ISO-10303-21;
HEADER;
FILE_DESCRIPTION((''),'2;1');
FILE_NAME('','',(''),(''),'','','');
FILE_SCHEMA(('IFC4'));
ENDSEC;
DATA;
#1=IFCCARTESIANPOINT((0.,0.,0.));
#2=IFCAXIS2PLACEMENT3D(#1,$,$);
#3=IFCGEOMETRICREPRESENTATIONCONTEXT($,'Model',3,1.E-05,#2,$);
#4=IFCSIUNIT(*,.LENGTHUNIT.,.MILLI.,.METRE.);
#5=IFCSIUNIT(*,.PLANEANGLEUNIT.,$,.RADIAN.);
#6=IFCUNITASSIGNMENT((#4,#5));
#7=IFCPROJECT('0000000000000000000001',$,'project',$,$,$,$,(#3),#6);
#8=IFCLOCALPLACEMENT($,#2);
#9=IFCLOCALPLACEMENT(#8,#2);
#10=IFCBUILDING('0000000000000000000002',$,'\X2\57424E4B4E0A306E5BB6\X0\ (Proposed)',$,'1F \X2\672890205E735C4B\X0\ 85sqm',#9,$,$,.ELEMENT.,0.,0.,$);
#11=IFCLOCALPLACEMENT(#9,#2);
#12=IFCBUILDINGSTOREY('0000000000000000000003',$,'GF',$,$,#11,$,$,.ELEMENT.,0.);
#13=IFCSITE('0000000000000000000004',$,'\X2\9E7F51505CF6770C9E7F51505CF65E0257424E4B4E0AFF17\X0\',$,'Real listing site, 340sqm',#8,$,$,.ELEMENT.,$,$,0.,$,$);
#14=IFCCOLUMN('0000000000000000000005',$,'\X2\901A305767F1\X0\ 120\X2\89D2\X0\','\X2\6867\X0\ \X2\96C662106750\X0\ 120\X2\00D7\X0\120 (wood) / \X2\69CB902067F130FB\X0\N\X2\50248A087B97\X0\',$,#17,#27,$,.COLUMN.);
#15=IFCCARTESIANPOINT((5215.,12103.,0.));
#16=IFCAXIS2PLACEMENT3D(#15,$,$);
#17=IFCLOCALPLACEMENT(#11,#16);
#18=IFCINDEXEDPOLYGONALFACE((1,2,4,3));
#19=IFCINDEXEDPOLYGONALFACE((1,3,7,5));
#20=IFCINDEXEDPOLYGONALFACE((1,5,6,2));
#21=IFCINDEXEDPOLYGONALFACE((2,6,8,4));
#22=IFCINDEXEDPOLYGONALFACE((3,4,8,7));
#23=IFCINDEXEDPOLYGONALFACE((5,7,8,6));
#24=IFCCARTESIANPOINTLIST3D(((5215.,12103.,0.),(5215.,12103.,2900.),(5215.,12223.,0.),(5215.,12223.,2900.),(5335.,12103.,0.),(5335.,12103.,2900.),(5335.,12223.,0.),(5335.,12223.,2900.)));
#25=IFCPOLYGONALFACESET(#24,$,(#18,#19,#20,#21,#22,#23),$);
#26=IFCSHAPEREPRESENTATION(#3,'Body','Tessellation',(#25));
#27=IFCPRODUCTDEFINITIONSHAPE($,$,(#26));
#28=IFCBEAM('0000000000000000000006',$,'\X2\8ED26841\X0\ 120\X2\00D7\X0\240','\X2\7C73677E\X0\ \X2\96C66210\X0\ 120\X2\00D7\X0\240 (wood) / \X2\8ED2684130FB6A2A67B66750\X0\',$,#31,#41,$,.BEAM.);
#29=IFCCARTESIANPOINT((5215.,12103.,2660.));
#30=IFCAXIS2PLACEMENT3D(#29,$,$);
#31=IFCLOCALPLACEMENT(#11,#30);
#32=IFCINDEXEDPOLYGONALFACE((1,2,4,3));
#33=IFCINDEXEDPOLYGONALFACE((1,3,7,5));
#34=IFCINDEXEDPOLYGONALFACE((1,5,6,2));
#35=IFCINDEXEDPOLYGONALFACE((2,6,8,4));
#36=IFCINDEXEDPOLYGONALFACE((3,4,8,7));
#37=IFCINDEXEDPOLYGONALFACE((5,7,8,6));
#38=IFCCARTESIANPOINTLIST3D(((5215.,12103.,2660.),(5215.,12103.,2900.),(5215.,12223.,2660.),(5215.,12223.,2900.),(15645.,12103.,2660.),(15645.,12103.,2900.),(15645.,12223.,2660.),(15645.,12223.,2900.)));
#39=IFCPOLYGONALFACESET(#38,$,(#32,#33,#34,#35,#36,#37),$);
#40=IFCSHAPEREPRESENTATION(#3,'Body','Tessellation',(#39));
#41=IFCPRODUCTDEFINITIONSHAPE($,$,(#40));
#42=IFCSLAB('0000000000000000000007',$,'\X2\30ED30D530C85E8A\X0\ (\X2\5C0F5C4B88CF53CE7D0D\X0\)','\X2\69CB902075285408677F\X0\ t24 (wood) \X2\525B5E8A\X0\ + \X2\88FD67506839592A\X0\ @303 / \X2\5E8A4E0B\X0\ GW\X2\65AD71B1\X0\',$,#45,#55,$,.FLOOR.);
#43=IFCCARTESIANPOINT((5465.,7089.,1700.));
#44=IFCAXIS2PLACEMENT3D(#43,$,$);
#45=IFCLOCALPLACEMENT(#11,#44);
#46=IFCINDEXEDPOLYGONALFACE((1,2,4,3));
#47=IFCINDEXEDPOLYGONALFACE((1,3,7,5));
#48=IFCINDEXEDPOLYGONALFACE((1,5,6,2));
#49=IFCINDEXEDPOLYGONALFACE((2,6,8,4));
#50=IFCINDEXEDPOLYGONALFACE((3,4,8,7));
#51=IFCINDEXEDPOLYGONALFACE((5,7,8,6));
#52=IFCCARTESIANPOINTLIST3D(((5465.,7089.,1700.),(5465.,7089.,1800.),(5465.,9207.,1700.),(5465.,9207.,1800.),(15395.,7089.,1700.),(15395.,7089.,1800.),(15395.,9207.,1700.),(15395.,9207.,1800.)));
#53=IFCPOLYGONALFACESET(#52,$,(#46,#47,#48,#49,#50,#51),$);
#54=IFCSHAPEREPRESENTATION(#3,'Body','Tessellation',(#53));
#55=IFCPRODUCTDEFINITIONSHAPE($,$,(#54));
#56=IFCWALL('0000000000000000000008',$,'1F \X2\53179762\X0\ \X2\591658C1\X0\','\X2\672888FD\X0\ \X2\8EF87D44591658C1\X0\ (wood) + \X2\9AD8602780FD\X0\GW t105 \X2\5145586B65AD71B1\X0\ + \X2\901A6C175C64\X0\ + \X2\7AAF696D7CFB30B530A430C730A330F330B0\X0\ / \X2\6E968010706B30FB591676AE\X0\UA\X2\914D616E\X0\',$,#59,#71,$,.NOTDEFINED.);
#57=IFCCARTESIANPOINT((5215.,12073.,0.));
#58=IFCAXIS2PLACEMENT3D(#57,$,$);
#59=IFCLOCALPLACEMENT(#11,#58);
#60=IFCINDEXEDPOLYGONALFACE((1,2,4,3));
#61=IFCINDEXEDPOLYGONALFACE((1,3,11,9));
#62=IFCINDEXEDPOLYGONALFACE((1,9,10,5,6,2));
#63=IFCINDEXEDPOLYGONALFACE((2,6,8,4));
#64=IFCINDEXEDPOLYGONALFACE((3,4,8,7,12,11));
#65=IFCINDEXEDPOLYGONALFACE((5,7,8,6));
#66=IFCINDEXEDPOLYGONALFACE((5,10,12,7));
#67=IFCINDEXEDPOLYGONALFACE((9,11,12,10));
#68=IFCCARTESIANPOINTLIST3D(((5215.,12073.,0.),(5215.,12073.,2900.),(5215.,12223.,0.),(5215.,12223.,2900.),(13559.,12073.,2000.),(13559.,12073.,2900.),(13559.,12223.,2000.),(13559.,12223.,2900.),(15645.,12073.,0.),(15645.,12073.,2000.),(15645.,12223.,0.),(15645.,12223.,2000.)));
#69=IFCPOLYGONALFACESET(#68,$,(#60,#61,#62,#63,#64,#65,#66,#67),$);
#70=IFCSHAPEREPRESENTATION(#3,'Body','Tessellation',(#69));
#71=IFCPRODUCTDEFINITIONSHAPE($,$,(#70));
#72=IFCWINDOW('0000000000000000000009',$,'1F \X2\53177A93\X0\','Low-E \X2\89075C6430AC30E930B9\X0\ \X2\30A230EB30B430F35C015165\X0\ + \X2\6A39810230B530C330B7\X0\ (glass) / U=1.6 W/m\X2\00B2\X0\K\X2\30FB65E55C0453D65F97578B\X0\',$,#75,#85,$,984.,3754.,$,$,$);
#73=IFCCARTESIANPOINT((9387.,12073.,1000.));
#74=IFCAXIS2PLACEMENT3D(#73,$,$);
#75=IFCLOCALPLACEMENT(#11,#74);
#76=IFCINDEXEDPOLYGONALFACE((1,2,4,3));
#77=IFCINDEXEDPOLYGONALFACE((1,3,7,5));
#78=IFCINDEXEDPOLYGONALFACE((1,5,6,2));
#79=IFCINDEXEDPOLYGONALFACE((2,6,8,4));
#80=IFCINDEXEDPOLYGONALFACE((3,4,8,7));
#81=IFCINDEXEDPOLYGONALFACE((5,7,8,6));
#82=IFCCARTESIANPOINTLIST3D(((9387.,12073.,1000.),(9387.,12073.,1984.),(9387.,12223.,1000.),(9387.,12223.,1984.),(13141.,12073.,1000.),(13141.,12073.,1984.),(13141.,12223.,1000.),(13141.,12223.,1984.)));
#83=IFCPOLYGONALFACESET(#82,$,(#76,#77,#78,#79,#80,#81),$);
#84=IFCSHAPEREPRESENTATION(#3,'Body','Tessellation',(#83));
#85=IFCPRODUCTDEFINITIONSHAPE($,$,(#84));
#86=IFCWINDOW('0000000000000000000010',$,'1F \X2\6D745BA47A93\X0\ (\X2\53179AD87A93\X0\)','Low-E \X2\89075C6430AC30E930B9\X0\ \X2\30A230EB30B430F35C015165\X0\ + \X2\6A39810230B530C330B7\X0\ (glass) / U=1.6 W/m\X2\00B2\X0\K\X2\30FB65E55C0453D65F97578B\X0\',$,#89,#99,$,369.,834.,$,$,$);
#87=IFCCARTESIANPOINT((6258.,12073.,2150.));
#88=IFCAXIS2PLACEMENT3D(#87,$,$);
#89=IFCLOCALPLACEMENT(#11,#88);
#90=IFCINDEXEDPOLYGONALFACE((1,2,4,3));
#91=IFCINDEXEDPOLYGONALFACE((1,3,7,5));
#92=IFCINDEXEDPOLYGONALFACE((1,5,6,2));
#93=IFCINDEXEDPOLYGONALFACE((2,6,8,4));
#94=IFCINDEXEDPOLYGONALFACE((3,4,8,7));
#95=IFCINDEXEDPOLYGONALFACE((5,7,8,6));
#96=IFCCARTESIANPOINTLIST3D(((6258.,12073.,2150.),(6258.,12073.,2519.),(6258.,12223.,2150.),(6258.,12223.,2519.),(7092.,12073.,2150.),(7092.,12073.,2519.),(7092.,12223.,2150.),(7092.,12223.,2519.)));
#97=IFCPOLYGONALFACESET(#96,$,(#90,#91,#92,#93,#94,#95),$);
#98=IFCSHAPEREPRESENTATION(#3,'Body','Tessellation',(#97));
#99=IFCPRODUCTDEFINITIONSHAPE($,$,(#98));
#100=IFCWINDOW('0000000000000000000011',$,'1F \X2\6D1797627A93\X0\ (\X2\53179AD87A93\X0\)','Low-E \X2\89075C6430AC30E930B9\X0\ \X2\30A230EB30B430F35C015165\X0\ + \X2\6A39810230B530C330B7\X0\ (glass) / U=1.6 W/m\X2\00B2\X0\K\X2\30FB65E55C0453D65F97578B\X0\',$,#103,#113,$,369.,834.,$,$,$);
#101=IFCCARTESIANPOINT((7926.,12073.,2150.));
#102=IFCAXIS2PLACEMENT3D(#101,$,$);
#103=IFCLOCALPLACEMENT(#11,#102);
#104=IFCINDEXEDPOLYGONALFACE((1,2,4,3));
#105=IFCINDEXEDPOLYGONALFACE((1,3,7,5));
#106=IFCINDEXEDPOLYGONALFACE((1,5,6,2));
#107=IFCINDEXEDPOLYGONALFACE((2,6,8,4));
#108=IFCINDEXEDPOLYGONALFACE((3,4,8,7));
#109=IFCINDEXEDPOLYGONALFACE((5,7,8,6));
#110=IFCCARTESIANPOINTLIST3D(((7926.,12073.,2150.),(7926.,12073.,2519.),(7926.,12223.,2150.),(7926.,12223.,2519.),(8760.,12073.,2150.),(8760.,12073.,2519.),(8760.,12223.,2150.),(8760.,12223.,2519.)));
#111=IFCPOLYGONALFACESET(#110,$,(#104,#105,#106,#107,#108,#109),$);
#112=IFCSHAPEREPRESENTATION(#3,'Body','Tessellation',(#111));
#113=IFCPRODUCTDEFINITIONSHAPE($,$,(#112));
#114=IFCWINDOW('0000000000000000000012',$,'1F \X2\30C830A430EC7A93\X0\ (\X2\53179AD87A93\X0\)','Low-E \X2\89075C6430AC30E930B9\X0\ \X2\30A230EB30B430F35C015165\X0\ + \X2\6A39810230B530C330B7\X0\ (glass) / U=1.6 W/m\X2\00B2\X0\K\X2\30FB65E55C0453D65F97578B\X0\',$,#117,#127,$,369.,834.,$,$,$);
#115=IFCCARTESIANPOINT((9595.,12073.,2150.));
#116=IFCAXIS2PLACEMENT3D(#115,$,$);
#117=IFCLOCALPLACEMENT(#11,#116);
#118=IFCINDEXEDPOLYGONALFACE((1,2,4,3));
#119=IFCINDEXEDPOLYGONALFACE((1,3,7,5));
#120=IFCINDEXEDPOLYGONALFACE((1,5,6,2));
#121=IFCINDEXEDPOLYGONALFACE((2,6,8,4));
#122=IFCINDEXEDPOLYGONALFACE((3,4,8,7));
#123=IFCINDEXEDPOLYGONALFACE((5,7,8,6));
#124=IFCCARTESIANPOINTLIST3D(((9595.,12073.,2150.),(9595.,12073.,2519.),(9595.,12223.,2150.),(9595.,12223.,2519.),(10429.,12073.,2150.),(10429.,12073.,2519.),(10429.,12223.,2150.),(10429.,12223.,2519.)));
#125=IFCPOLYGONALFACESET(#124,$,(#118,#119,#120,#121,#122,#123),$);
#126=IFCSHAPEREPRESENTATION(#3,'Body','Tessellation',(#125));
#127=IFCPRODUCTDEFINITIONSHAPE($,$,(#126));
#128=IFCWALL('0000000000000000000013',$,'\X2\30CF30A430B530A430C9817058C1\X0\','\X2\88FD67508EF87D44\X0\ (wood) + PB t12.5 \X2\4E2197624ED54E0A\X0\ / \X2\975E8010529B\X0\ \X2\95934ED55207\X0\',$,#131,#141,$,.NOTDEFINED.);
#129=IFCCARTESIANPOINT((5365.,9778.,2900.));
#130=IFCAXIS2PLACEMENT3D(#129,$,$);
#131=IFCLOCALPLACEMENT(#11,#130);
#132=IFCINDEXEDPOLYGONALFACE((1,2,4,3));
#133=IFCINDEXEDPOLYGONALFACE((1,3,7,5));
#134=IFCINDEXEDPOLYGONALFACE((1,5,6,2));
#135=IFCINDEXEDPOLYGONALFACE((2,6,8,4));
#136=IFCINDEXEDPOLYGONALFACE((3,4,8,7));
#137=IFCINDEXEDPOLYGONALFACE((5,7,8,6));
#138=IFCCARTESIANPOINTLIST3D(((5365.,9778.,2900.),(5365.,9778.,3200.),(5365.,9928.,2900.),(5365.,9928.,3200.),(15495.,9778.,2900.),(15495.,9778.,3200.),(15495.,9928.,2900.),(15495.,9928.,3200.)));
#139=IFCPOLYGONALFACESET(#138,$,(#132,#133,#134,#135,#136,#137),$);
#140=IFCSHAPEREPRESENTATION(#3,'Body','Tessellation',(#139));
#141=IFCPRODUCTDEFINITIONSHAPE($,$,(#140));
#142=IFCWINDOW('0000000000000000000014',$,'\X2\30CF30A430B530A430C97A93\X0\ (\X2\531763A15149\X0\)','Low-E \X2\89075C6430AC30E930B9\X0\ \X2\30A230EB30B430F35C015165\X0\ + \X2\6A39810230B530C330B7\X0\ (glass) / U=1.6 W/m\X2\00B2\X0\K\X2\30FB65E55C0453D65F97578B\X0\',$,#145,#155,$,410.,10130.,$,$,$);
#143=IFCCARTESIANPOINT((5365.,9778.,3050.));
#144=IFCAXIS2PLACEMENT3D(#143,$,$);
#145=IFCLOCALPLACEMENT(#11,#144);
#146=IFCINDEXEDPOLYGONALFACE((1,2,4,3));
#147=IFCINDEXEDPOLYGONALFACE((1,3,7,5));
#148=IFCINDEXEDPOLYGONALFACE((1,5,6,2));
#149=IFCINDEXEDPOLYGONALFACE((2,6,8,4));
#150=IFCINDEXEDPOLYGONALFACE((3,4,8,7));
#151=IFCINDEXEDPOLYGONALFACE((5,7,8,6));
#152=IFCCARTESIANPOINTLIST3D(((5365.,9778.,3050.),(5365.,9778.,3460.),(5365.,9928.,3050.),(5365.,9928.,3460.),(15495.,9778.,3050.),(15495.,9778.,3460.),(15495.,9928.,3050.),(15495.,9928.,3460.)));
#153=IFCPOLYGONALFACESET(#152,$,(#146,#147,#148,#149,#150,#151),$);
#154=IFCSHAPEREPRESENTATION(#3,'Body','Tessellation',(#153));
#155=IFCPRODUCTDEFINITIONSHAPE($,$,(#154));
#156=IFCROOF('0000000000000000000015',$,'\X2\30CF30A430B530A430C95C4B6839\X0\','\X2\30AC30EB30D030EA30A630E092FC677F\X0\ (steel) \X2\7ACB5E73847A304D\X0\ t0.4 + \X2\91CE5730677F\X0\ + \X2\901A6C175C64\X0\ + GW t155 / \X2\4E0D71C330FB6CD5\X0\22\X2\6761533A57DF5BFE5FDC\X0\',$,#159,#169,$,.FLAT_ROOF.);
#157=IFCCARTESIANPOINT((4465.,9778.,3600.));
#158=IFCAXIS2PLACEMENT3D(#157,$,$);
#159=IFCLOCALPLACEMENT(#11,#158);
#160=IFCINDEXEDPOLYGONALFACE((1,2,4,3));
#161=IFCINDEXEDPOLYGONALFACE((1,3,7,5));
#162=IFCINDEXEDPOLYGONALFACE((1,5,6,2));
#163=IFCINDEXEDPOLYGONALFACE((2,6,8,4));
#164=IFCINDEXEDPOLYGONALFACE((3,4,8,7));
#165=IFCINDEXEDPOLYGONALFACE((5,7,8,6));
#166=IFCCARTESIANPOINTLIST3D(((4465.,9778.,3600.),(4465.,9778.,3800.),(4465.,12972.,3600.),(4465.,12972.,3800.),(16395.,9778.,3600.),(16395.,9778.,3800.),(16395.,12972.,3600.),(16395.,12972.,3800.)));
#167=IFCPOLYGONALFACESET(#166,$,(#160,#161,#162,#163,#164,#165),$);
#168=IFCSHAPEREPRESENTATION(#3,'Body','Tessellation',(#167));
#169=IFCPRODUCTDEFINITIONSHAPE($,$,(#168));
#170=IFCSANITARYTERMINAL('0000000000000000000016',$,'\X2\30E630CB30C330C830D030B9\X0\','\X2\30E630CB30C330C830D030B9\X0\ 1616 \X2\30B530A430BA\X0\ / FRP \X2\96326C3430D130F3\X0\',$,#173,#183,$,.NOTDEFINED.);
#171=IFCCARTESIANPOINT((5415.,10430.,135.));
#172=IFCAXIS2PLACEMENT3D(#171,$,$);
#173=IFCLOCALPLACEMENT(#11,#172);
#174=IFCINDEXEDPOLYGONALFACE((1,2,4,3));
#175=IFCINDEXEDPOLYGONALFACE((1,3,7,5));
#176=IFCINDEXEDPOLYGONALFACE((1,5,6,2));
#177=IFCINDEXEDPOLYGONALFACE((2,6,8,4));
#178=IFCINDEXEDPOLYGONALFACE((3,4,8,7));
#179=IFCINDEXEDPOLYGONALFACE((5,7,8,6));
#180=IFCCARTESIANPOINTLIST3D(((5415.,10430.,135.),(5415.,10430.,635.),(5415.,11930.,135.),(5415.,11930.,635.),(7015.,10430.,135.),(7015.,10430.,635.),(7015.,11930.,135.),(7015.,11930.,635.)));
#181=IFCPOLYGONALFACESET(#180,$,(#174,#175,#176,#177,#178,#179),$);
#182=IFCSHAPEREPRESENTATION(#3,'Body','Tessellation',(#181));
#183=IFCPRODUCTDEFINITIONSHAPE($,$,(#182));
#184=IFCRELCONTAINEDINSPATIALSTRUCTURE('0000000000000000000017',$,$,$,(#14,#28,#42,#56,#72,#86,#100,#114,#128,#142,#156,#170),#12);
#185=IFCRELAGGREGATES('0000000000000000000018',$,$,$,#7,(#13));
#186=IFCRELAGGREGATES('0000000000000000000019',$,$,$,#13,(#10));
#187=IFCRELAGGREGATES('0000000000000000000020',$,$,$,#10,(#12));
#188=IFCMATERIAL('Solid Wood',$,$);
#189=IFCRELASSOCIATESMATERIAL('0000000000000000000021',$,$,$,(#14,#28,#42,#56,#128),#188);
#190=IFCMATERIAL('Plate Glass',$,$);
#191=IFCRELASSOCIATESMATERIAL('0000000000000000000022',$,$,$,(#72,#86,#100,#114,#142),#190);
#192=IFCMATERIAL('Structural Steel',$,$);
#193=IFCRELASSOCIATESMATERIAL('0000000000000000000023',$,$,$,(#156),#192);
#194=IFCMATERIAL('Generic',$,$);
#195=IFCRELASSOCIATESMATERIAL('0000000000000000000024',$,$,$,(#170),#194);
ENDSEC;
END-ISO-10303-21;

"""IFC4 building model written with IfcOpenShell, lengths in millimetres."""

from ifc_helpers import new_model, si_unit, frame, frame_2d, origin, place, context, project, spatial, rectangle, extrude, material, element, fill, save


model = new_model("IFC4")

# Units and contexts
model_context = context("Model", 3, precision=1e-05, world=origin())
ifc_project = project(units=[si_unit("LENGTHUNIT", "METRE", prefix="MILLI"), si_unit("PLANEANGLEUNIT", "RADIAN")], contexts=[model_context])

# Site, building, storey
site_placement = place(None, origin())
site = spatial("IfcSite", under=ifc_project, at=site_placement, Name="鹿児島県鹿児島市坂之上７", ObjectType="Real listing site, 340sqm", CompositionType="ELEMENT", RefElevation=0.0)
building_placement = place(site_placement, origin())
building = spatial("IfcBuilding", under=site, at=building_placement, Name="坂之上の家 (Proposed)", ObjectType="1F 木造平屋 85sqm", CompositionType="ELEMENT", ElevationOfRefHeight=0.0, ElevationOfTerrain=0.0)
storey_placement = place(building_placement, origin())
storey = spatial("IfcBuildingStorey", under=building, at=storey_placement, Name="GF", CompositionType="ELEMENT", Elevation=0.0)

# Column
ifc_material_1 = material(Name="Solid Wood")
column_1_placement = place(storey_placement, frame((5215.0, 12103.0, 0.0)))
element("IfcColumn", 1, at=column_1_placement, inside=storey, material=ifc_material_1, Name="通し柱 120角", Description="桧 集成材 120×120 (wood) / 構造柱・N値計算", PredefinedType="COLUMN", context=model_context, shape_type="SweptSolid", body=[
    extrude(rectangle(XDim=120.0, YDim=120.0, at=frame_2d((60.0, 60.0))), frame((5215.0, 12103.0, 0.0)), (0.0, 0.0, 1.0), 2900.0),
])

# Beam
beam_1_placement = place(storey_placement, frame((5215.0, 12103.0, 2660.0)))
element("IfcBeam", 2, at=beam_1_placement, inside=storey, material=ifc_material_1, Name="軒桁 120×240", Description="米松 集成 120×240 (wood) / 軒桁・横架材", PredefinedType="BEAM", context=model_context, shape_type="SweptSolid", body=[
    extrude(rectangle(XDim=10430.0, YDim=120.0, at=frame_2d((5215.0, 60.0))), frame((5215.0, 12103.0, 2660.0)), (0.0, 0.0, 1.0), 240.0),
])

# Slab
slab_placement = place(storey_placement, frame((5465.0, 7089.0, 1700.0)))
element("IfcSlab", 3, at=slab_placement, inside=storey, material=ifc_material_1, Name="ロフト床 (小屋裏収納)", Description="構造用合板 t24 (wood) 剛床 + 製材根太 @303 / 床下 GW断熱", PredefinedType="FLOOR", context=model_context, shape_type="SweptSolid", body=[
    extrude(rectangle(XDim=9930.0, YDim=2118.0, at=frame_2d((4965.0, 1059.0))), frame((5465.0, 7089.0, 1700.0)), (0.0, 0.0, 1.0), 100.0),
])

# Wall, openings, windows
wall_1_placement = place(storey_placement, frame((5215.0, 12073.0, 0.0)))
wall_1 = element("IfcWall", 4, at=wall_1_placement, inside=storey, material=ifc_material_1, Name="1F 北面 外壁", Description="木製 軸組外壁 (wood) + 高性能GW t105 充填断熱 + 通気層 + 窯業系サイディング / 準耐火・外皮UA配慮", PredefinedType="NOTDEFINED", context=model_context, shape_type="SweptSolid", body=[
    extrude(rectangle(XDim=10430.0, YDim=150.0, at=frame_2d((5215.0, 75.0))), frame((5215.0, 12073.0, 0.0)), (0.0, 0.0, 1.0), 2900.0),
])
opening_1_placement = place(storey_placement, frame((9387.0, 12073.0, 1000.0)))
opening_1 = element("IfcOpeningElement", 5, at=opening_1_placement, cuts=wall_1, PredefinedType="NOTDEFINED", context=model_context, shape_type="SweptSolid", body=[
    extrude(rectangle(XDim=3754.0, YDim=150.0, at=frame_2d((1877.0, 75.0))), frame((9387.0, 12073.0, 1000.0)), (0.0, 0.0, 1.0), 984.0),
])
opening_2_placement = place(storey_placement, frame((6258.0, 12073.0, 2150.0)))
opening_2 = element("IfcOpeningElement", 6, at=opening_2_placement, cuts=wall_1, PredefinedType="NOTDEFINED", context=model_context, shape_type="SweptSolid", body=[
    extrude(rectangle(XDim=834.0, YDim=150.0, at=frame_2d((417.0, 75.0))), frame((6258.0, 12073.0, 2150.0)), (0.0, 0.0, 1.0), 369.0),
])
opening_3_placement = place(storey_placement, frame((7926.0, 12073.0, 2150.0)))
opening_3 = element("IfcOpeningElement", 7, at=opening_3_placement, cuts=wall_1, PredefinedType="NOTDEFINED", context=model_context, shape_type="SweptSolid", body=[
    extrude(rectangle(XDim=834.0, YDim=150.0, at=frame_2d((417.0, 75.0))), frame((7926.0, 12073.0, 2150.0)), (0.0, 0.0, 1.0), 369.0),
])
opening_4_placement = place(storey_placement, frame((9595.0, 12073.0, 2150.0)))
opening_4 = element("IfcOpeningElement", 8, at=opening_4_placement, cuts=wall_1, PredefinedType="NOTDEFINED", context=model_context, shape_type="SweptSolid", body=[
    extrude(rectangle(XDim=834.0, YDim=150.0, at=frame_2d((417.0, 75.0))), frame((9595.0, 12073.0, 2150.0)), (0.0, 0.0, 1.0), 369.0),
])
ifc_material_2 = material(Name="Plate Glass")
window_1_placement = place(storey_placement, frame((9387.0, 12073.0, 1000.0)))
window_1 = element("IfcWindow", 9, at=window_1_placement, inside=storey, material=ifc_material_2, Name="1F 北窓", Description="Low-E 複層ガラス アルゴン封入 + 樹脂サッシ (glass) / U=1.6 W/m²K・日射取得型", OverallHeight=984.0, OverallWidth=3754.0, context=model_context, shape_type="SweptSolid", body=[
    extrude(rectangle(XDim=3754.0, YDim=150.0, at=frame_2d((1877.0, 75.0))), frame((9387.0, 12073.0, 1000.0)), (0.0, 0.0, 1.0), 984.0),
])
fill(opening_1, window_1)
window_2_placement = place(storey_placement, frame((6258.0, 12073.0, 2150.0)))
window_2 = element("IfcWindow", 10, at=window_2_placement, inside=storey, material=ifc_material_2, Name="1F 浴室窓 (北高窓)", Description="Low-E 複層ガラス アルゴン封入 + 樹脂サッシ (glass) / U=1.6 W/m²K・日射取得型", OverallHeight=369.0, OverallWidth=834.0, context=model_context, shape_type="SweptSolid", body=[
    extrude(rectangle(XDim=834.0, YDim=150.0, at=frame_2d((417.0, 75.0))), frame((6258.0, 12073.0, 2150.0)), (0.0, 0.0, 1.0), 369.0),
])
fill(opening_2, window_2)
window_3_placement = place(storey_placement, frame((7926.0, 12073.0, 2150.0)))
window_3 = element("IfcWindow", 11, at=window_3_placement, inside=storey, material=ifc_material_2, Name="1F 洗面窓 (北高窓)", Description="Low-E 複層ガラス アルゴン封入 + 樹脂サッシ (glass) / U=1.6 W/m²K・日射取得型", OverallHeight=369.0, OverallWidth=834.0, context=model_context, shape_type="SweptSolid", body=[
    extrude(rectangle(XDim=834.0, YDim=150.0, at=frame_2d((417.0, 75.0))), frame((7926.0, 12073.0, 2150.0)), (0.0, 0.0, 1.0), 369.0),
])
fill(opening_3, window_3)
window_4_placement = place(storey_placement, frame((9595.0, 12073.0, 2150.0)))
window_4 = element("IfcWindow", 12, at=window_4_placement, inside=storey, material=ifc_material_2, Name="1F トイレ窓 (北高窓)", Description="Low-E 複層ガラス アルゴン封入 + 樹脂サッシ (glass) / U=1.6 W/m²K・日射取得型", OverallHeight=369.0, OverallWidth=834.0, context=model_context, shape_type="SweptSolid", body=[
    extrude(rectangle(XDim=834.0, YDim=150.0, at=frame_2d((417.0, 75.0))), frame((9595.0, 12073.0, 2150.0)), (0.0, 0.0, 1.0), 369.0),
])
fill(opening_4, window_4)

# Wall, opening, window
wall_2_placement = place(storey_placement, frame((5365.0, 9778.0, 2900.0)))
wall_2 = element("IfcWall", 13, at=wall_2_placement, inside=storey, material=ifc_material_1, Name="ハイサイド腰壁", Description="製材軸組 (wood) + PB t12.5 両面仕上 / 非耐力 間仕切", PredefinedType="NOTDEFINED", context=model_context, shape_type="SweptSolid", body=[
    extrude(rectangle(XDim=10130.0, YDim=150.0, at=frame_2d((5065.0, 75.0))), frame((5365.0, 9778.0, 2900.0)), (0.0, 0.0, 1.0), 700.0),
])
opening_5_placement = place(storey_placement, frame((5365.0, 9778.0, 3050.0)))
opening_5 = element("IfcOpeningElement", 14, at=opening_5_placement, cuts=wall_2, PredefinedType="NOTDEFINED", context=model_context, shape_type="SweptSolid", body=[
    extrude(rectangle(XDim=10130.0, YDim=150.0, at=frame_2d((5065.0, 75.0))), frame((5365.0, 9778.0, 3050.0)), (0.0, 0.0, 1.0), 410.0),
])
window_5_placement = place(storey_placement, frame((5365.0, 9778.0, 3050.0)))
window_5 = element("IfcWindow", 15, at=window_5_placement, inside=storey, material=ifc_material_2, Name="ハイサイド窓 (北採光)", Description="Low-E 複層ガラス アルゴン封入 + 樹脂サッシ (glass) / U=1.6 W/m²K・日射取得型", OverallHeight=410.0, OverallWidth=10130.0, context=model_context, shape_type="SweptSolid", body=[
    extrude(rectangle(XDim=10130.0, YDim=150.0, at=frame_2d((5065.0, 75.0))), frame((5365.0, 9778.0, 3050.0)), (0.0, 0.0, 1.0), 410.0),
])
fill(opening_5, window_5)

# Roof
ifc_material_3 = material(Name="Structural Steel")
roof_placement = place(storey_placement, frame((4465.0, 9778.0, 3600.0)))
element("IfcRoof", 16, at=roof_placement, inside=storey, material=ifc_material_3, Name="ハイサイド屋根", Description="ガルバリウム鋼板 (steel) 立平葺き t0.4 + 野地板 + 通気層 + GW t155 / 不燃・法22条区域対応", PredefinedType="FLAT_ROOF", context=model_context, shape_type="SweptSolid", body=[
    extrude(rectangle(XDim=11930.0, YDim=3194.0, at=frame_2d((5965.0, 1597.0))), frame((4465.0, 9778.0, 3600.0)), (0.0, 0.0, 1.0), 200.0),
])

# Sanitary terminal
ifc_material_4 = material(Name="Generic")
sanitary_terminal_placement = place(storey_placement, frame((5415.0, 10430.0, 135.0)))
element("IfcSanitaryTerminal", 17, at=sanitary_terminal_placement, inside=storey, material=ifc_material_4, Name="ユニットバス", Description="ユニットバス 1616 サイズ / FRP 防水パン", PredefinedType="NOTDEFINED", context=model_context, shape_type="SweptSolid", body=[
    extrude(rectangle(XDim=1600.0, YDim=1500.0, at=frame_2d((800.0, 750.0))), frame((5415.0, 10430.0, 135.0)), (0.0, 0.0, 1.0), 500.0),
])

save(model, "model.ifc")
